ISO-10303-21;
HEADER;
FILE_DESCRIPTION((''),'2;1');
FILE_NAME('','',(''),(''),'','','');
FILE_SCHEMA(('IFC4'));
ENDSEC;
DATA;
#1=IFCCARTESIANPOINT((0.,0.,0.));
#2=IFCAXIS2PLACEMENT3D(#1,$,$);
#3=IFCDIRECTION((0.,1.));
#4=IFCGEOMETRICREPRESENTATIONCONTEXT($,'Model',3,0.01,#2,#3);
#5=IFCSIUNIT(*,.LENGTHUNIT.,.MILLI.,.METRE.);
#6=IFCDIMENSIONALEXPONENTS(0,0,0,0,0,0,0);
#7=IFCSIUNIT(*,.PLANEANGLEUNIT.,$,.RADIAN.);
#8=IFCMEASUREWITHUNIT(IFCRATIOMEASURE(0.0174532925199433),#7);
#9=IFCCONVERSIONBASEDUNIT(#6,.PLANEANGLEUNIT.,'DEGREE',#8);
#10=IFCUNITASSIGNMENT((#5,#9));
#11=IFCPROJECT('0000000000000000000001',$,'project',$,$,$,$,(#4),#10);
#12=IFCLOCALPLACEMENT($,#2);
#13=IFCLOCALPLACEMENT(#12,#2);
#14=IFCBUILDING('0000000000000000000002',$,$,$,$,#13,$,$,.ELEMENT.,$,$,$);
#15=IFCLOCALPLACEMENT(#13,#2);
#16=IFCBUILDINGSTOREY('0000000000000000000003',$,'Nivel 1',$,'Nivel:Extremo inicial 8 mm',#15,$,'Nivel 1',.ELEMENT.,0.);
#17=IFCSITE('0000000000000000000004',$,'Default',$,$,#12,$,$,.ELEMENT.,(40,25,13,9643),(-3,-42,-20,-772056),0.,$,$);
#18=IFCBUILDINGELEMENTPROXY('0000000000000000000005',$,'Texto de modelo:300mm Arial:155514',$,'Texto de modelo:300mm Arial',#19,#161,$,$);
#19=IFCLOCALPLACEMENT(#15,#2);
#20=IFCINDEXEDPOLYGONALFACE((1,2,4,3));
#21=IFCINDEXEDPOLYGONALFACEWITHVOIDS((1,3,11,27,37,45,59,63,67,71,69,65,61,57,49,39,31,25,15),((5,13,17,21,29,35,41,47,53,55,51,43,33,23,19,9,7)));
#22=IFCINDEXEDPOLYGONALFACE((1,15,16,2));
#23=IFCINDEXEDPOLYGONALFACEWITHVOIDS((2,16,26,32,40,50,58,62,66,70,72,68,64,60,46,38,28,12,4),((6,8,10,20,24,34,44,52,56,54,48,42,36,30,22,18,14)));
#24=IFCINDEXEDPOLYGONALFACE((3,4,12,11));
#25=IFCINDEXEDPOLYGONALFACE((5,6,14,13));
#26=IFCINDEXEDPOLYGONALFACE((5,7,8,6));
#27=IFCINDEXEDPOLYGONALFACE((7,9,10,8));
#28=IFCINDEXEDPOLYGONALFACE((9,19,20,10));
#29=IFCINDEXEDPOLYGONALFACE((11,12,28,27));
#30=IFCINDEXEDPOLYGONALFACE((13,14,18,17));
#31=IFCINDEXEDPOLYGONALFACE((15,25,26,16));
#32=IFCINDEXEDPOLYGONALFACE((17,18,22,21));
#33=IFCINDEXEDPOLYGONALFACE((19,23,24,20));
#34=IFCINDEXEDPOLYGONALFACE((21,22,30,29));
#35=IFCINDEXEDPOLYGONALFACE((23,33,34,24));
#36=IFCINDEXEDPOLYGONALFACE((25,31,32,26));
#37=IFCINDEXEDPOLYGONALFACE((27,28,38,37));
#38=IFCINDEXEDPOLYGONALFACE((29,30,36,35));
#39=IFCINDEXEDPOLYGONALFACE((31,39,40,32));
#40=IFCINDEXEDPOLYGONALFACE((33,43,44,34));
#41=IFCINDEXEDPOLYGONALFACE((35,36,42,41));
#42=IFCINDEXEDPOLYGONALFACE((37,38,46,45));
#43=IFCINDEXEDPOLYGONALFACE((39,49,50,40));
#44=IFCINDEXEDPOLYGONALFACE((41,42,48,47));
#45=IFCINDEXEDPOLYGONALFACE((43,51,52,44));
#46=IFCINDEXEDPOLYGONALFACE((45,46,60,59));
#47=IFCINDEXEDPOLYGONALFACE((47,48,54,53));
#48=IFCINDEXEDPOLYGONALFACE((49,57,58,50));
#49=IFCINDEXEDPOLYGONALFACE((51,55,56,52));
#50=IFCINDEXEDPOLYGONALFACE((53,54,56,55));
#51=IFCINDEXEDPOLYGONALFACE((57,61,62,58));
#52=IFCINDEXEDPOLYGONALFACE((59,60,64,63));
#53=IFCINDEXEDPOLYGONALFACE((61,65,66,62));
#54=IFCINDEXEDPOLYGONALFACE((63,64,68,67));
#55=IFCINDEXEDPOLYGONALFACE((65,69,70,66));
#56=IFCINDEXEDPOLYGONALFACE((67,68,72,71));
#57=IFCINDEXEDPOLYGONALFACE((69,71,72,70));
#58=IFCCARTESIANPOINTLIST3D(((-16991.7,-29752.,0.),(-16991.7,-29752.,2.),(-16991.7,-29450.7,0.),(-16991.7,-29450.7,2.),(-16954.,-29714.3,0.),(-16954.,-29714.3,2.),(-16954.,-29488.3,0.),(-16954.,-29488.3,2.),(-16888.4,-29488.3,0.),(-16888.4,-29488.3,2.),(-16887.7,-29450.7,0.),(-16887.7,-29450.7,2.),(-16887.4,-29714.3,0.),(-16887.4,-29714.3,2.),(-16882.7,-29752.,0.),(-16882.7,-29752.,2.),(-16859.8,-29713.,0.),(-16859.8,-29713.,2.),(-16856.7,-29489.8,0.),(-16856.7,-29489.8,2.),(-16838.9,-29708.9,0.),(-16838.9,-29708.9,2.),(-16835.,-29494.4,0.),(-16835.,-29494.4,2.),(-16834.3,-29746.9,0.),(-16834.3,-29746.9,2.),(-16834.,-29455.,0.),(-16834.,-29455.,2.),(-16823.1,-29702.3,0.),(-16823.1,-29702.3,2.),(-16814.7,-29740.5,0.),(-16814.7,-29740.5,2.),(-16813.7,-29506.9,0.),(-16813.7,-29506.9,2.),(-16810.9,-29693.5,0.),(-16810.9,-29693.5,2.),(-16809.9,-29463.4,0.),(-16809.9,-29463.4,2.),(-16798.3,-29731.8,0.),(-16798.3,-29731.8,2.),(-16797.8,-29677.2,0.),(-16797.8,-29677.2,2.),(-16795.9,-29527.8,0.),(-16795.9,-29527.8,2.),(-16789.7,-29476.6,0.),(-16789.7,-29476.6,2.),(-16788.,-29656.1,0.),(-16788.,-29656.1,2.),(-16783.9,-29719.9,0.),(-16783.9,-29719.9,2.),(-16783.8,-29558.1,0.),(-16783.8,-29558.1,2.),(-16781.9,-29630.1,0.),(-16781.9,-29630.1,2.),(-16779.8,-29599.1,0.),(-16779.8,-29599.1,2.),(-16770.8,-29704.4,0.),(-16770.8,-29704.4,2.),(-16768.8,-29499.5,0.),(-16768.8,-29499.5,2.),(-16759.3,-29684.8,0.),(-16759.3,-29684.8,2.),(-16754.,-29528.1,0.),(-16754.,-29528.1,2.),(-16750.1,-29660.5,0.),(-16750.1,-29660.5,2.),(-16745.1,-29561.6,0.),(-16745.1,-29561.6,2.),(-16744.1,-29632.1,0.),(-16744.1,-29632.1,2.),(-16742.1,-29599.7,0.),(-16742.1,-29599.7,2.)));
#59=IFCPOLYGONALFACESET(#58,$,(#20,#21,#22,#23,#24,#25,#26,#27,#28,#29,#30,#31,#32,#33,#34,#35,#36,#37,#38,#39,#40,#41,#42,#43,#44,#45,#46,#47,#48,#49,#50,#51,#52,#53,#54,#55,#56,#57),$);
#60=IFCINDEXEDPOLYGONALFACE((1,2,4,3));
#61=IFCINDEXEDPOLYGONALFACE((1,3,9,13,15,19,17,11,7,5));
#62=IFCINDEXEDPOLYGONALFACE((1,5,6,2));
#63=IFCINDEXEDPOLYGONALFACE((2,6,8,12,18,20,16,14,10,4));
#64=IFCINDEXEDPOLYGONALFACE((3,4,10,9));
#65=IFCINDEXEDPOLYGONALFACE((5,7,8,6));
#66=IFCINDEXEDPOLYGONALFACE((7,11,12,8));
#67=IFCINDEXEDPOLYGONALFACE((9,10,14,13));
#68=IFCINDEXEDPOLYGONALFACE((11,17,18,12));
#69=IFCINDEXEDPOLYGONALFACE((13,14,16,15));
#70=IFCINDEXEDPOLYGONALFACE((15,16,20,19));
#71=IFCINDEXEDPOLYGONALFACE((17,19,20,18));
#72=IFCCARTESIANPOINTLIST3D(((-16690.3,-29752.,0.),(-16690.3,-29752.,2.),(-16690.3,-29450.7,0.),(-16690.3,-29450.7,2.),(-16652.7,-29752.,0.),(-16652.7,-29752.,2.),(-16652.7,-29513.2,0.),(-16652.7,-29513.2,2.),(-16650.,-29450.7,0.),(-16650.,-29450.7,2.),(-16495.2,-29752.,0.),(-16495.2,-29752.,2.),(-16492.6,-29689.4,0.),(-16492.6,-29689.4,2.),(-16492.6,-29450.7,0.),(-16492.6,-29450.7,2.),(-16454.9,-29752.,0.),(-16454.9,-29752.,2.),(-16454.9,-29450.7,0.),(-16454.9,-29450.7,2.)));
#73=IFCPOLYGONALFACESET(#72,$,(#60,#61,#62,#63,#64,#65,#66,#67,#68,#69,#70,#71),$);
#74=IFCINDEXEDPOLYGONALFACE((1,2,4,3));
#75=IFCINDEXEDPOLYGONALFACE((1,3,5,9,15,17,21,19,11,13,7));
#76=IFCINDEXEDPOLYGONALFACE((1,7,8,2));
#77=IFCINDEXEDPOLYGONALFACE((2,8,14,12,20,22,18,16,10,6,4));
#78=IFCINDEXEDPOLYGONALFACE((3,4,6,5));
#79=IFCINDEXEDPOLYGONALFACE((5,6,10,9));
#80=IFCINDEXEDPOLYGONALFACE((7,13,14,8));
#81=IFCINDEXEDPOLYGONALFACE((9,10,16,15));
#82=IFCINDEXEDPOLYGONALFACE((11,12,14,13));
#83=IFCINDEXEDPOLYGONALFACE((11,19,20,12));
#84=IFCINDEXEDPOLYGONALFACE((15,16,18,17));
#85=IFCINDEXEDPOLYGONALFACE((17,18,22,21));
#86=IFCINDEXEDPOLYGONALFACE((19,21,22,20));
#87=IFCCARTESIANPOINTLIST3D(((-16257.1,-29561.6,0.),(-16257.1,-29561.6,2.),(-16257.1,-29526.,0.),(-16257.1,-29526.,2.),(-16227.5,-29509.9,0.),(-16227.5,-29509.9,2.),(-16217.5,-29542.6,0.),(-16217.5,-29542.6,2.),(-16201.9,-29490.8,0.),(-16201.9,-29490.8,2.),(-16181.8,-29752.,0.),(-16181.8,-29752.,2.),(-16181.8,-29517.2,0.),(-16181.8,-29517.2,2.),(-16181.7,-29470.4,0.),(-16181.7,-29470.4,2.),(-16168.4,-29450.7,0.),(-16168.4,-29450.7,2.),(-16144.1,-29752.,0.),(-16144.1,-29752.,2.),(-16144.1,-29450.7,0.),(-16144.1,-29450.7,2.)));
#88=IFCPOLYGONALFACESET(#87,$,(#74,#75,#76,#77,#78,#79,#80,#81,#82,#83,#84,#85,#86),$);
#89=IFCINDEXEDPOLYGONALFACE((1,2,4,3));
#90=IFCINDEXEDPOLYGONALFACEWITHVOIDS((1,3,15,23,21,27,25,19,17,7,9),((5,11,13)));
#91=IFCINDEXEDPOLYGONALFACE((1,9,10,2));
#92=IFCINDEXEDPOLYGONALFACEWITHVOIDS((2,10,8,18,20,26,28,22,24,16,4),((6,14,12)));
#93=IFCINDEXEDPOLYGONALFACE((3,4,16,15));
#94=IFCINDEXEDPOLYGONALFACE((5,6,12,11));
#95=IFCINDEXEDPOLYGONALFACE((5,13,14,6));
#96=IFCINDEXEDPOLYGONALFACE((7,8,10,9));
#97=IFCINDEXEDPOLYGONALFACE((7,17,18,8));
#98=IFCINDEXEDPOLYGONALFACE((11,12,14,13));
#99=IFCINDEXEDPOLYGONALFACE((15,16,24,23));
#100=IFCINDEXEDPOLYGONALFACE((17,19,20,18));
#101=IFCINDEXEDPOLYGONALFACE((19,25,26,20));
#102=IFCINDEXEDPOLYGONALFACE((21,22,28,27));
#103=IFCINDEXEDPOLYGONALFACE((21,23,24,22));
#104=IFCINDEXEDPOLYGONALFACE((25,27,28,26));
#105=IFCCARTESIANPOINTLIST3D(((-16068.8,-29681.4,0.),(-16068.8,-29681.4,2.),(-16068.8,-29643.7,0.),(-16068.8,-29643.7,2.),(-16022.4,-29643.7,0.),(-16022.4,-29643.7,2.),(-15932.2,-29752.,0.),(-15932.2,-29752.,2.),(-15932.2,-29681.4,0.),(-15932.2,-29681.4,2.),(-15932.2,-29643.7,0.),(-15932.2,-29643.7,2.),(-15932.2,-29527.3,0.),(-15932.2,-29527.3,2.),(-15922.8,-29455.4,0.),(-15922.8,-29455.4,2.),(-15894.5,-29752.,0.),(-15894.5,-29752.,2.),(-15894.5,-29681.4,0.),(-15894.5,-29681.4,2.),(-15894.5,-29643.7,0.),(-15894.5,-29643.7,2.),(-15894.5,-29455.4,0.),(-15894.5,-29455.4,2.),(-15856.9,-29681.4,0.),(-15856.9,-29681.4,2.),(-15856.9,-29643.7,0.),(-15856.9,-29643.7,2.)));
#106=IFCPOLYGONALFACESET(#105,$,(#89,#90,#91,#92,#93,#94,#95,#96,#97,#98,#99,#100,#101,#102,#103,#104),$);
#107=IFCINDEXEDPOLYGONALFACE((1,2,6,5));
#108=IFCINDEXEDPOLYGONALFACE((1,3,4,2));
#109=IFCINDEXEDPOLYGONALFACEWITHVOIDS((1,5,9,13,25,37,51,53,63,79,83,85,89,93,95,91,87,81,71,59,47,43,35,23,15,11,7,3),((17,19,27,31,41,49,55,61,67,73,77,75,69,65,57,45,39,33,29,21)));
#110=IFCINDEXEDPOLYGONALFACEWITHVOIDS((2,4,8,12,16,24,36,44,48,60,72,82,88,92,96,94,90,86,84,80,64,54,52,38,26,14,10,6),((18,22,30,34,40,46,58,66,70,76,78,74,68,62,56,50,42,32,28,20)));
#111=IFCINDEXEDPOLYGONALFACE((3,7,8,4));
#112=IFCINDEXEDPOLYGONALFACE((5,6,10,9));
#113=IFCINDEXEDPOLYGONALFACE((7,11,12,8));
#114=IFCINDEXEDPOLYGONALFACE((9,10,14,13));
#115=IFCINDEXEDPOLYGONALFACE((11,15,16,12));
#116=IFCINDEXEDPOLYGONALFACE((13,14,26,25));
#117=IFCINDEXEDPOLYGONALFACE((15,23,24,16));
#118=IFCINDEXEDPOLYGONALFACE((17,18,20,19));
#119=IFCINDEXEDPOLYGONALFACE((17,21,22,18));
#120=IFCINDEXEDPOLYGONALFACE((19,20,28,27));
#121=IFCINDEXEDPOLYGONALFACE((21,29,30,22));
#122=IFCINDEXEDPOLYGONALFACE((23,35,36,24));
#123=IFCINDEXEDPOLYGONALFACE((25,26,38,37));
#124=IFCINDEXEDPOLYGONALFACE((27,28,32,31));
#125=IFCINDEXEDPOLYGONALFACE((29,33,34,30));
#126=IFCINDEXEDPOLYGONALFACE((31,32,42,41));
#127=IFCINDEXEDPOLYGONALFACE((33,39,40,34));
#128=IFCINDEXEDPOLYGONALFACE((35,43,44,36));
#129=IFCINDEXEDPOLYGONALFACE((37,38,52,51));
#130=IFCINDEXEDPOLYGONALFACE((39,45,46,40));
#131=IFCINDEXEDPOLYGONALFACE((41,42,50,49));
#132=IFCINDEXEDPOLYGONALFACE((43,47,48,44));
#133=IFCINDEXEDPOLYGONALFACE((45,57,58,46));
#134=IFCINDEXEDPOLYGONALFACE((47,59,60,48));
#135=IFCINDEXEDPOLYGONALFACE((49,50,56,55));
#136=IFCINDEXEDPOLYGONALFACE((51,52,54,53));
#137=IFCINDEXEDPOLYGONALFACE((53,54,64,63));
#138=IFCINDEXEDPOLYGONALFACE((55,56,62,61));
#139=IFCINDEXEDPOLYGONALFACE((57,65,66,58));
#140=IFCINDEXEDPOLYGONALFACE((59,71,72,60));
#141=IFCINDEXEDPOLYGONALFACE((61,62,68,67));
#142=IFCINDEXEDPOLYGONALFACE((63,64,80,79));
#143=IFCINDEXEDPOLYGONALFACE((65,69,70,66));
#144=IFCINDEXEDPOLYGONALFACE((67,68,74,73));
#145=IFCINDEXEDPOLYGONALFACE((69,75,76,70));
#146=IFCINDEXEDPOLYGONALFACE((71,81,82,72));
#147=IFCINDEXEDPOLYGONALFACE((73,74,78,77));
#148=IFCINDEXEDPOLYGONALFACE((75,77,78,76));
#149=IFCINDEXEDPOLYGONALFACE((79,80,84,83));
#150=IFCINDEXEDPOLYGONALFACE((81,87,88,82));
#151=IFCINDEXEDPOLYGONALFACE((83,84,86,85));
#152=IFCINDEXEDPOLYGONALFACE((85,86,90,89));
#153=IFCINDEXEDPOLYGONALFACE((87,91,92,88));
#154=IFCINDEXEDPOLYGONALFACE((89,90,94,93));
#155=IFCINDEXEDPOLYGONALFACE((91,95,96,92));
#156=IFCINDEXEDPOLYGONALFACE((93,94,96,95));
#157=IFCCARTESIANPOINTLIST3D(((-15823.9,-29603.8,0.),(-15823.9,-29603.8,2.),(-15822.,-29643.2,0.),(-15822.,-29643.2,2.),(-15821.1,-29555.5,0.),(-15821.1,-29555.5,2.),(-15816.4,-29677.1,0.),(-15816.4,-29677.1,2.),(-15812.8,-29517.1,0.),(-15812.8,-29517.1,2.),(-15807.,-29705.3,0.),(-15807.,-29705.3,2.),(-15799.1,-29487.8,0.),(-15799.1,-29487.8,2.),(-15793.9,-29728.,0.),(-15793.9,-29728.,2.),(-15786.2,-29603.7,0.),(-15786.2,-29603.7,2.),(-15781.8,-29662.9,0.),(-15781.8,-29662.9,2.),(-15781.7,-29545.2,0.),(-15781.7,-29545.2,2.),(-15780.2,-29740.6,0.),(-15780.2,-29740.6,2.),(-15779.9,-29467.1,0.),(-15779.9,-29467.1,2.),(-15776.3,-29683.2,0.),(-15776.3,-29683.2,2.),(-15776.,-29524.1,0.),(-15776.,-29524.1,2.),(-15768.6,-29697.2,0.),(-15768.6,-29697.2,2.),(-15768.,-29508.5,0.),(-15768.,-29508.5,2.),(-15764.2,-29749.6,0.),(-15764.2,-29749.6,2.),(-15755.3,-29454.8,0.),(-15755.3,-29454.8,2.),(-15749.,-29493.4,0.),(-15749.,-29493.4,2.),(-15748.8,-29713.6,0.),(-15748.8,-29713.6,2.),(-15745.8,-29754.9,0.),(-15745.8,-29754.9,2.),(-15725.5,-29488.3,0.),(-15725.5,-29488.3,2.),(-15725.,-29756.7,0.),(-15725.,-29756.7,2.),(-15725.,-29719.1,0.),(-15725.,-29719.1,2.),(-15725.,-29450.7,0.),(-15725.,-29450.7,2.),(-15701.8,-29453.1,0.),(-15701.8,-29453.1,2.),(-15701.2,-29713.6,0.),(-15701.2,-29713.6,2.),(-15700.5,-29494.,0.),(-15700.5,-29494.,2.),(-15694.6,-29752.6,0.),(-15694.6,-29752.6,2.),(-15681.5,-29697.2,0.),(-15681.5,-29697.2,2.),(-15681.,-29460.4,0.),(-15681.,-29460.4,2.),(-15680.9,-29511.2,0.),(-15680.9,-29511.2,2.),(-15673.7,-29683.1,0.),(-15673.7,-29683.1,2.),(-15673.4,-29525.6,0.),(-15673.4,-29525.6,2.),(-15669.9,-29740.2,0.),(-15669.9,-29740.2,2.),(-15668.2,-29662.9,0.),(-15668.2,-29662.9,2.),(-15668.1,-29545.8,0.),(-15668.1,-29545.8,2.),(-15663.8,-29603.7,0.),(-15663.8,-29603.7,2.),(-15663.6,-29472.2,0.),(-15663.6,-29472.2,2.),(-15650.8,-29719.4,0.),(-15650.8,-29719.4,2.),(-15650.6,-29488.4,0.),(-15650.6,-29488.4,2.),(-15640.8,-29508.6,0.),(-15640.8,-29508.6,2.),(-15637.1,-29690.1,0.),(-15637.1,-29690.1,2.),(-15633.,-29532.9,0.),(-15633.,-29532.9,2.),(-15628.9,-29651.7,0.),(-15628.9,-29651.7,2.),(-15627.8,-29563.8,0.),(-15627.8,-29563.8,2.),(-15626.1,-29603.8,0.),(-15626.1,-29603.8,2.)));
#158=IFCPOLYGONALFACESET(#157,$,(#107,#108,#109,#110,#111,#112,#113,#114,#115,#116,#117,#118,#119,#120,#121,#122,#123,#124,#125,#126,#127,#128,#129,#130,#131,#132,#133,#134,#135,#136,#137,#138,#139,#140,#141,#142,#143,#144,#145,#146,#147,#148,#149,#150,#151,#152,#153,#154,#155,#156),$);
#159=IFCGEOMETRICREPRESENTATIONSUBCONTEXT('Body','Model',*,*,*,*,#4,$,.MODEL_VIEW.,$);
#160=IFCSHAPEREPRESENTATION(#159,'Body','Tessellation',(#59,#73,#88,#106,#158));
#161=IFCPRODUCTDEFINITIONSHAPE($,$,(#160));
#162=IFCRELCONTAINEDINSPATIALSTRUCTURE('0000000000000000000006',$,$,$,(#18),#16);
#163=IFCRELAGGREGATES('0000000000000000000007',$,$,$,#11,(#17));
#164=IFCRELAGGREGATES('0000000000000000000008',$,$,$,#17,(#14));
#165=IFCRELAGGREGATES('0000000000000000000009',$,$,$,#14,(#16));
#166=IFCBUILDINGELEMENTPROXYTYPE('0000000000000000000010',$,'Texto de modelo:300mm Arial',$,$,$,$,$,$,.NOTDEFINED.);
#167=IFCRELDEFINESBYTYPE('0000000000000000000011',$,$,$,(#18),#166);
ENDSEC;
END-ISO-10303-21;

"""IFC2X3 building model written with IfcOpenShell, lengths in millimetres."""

from ifc_helpers import new_model, entity, si_unit, converted_unit, direction, frame, origin, place, context, subcontext, project, spatial, polyline, outline, extrude, type_object, element, save


model = new_model("IFC2X3")

# Units and contexts
model_context = context("Model", 3, precision=0.01, world=origin(), true_north=direction((0.0, 1.0)))
body_context = subcontext(model_context, "Body", "Model", "MODEL_VIEW")
ifc_project = project(units=[si_unit("LENGTHUNIT", "METRE", prefix="MILLI"), converted_unit("PLANEANGLEUNIT", "DEGREE", entity("IfcRatioMeasure", 0.0174532925199433), si_unit("PLANEANGLEUNIT", "RADIAN"), dimensions=[0, 0, 0, 0, 0, 0, 0])], contexts=[model_context])

# Site, building, storey
site_placement = place(None, origin())
site = spatial("IfcSite", under=ifc_project, at=site_placement, Name="Default", CompositionType="ELEMENT", RefLatitude=(40, 25, 13, 9643), RefLongitude=(-3, -42, -20, -772056), RefElevation=0.0)
building_placement = place(site_placement, origin())
building = spatial("IfcBuilding", under=site, at=building_placement, CompositionType="ELEMENT")
storey_placement = place(building_placement, origin())
storey = spatial("IfcBuildingStorey", under=building, at=storey_placement, Name="Nivel 1", ObjectType="Nivel:Extremo inicial 8 mm", LongName="Nivel 1", CompositionType="ELEMENT", Elevation=0.0)

# Building element proxy
building_element_proxy_type_1 = type_object("IfcBuildingElementProxyType", Name="Texto de modelo:300mm Arial", PredefinedType="NOTDEFINED")
proxy_1_placement = place(storey_placement, frame((-16991.7, -29756.7, 0.0)))
element("IfcBuildingElementProxy", 1, at=proxy_1_placement, inside=storey, type_object=building_element_proxy_type_1, Name="Texto de modelo:300mm Arial:155514", ObjectType="Texto de modelo:300mm Arial", context=body_context, shape_type="SweptSolid", body=[
    extrude(outline(polyline([(-178.4, -141.0), (-69.4, -141.0), (-21.0, -135.8), (-1.4, -129.5), (15.0, -120.7), (29.4, -108.9), (42.6, -93.4), (54.0, -73.7), (63.2, -49.5), (69.2, -21.0), (71.2, 11.3), (68.2, 49.4), (59.3, 83.0), (44.5, 111.5), (23.7, 134.5), (3.4, 147.7), (-20.6, 156.1), (-74.4, 160.4), (-178.4, 160.4), (-178.4, -141.0)]), holes=[polyline([(-140.7, -103.3), (-140.7, 122.7), (-75.1, 122.7), (-43.3, 121.2), (-21.7, 116.7), (-0.4, 104.1), (17.4, 83.3), (29.5, 53.0), (33.5, 11.9), (31.5, -19.1), (25.3, -45.1), (15.5, -66.2), (2.4, -82.5), (-9.8, -91.3), (-25.6, -97.9), (-46.5, -101.9), (-74.1, -103.3), (-140.7, -103.3)])]), frame((178.4, 145.7, 0.0)), (0.0, 0.0, 1.0), 2.0),
    extrude(outline(polyline([(-117.7, -150.7), (-80.1, -150.7), (-80.1, 88.1), (77.4, -150.7), (117.7, -150.7), (117.7, 150.7), (80.1, 150.7), (80.1, -88.1), (-77.4, 150.7), (-117.7, 150.7), (-117.7, -150.7)])), frame((419.1, 155.4, 0.0)), (0.0, 0.0, 1.0), 2.0),
    extrude(outline(polyline([(-204.4, -52.5), (97.0, -52.5), (97.0, -28.2), (77.2, -14.9), (56.9, 5.3), (37.7, 30.9), (21.6, 60.5), (-14.0, 60.5), (5.0, 20.8), (30.4, -14.9), (-204.4, -14.9), (-204.4, -52.5)])), frame((795.1, 209.1, 0.0), z_axis=(0.0, 0.0, 1.0), x_axis=(0.0, 1.0, 0.0)), (0.0, 0.0, 1.0), 2.0),
    extrude(outline(polyline([(-3.4, -109.2), (34.2, -109.2), (34.2, -38.5), (71.9, -38.5), (71.9, -0.9), (34.2, -0.9), (34.2, 187.5), (6.0, 187.5), (-140.0, -0.9), (-140.0, -38.5), (-3.4, -38.5), (-3.4, -109.2)]), holes=[polyline([(-3.4, -0.9), (-93.6, -0.9), (-3.4, 115.5), (-3.4, -0.9)])]), frame((1062.9, 113.9, 0.0)), (0.0, 0.0, 1.0), 2.0),
    extrude(outline(polyline([(-5.6, -99.5), (33.9, -99.5), (68.0, -95.5), (96.7, -87.5), (120.0, -75.5), (133.2, -62.4), (142.9, -46.8), (149.1, -28.7), (151.9, -8.0), (149.2, 22.6), (138.0, 47.8), (118.2, 67.9), (89.5, 82.9), (51.6, 93.0), (3.8, 98.0), (-36.2, 98.2), (-67.3, 94.5), (-91.9, 87.9), (-112.6, 79.0), (-129.4, 66.8), (-142.0, 50.0), (-150.3, 29.6), (-153.8, 6.5), (-151.2, -23.9), (-140.1, -49.1), (-120.3, -69.2), (-91.7, -84.4), (-53.6, -94.5), (-5.6, -99.5)]), holes=[polyline([(-3.9, -61.9), (-62.1, -54.6), (-82.9, -47.9), (-98.1, -39.2), (-112.3, -19.5), (-116.2, 4.3), (-109.3, 28.9), (-91.2, 47.7), (-76.5, 54.5), (-56.1, 58.9), (1.9, 60.4), (60.8, 53.2), (80.8, 46.7), (94.5, 38.3), (109.9, 17.8), (114.3, -6.3), (107.7, -29.8), (90.4, -48.7), (76.0, -55.8), (55.5, -60.3), (-3.9, -61.9)])]), frame((1267.5, 152.1, 0.0), z_axis=(0.0, 0.0, 1.0), x_axis=(0.047515, -0.998871, 0.0)), (0.0, 0.0, 1.0), 2.0),
])

save(model, "model.ifc")
